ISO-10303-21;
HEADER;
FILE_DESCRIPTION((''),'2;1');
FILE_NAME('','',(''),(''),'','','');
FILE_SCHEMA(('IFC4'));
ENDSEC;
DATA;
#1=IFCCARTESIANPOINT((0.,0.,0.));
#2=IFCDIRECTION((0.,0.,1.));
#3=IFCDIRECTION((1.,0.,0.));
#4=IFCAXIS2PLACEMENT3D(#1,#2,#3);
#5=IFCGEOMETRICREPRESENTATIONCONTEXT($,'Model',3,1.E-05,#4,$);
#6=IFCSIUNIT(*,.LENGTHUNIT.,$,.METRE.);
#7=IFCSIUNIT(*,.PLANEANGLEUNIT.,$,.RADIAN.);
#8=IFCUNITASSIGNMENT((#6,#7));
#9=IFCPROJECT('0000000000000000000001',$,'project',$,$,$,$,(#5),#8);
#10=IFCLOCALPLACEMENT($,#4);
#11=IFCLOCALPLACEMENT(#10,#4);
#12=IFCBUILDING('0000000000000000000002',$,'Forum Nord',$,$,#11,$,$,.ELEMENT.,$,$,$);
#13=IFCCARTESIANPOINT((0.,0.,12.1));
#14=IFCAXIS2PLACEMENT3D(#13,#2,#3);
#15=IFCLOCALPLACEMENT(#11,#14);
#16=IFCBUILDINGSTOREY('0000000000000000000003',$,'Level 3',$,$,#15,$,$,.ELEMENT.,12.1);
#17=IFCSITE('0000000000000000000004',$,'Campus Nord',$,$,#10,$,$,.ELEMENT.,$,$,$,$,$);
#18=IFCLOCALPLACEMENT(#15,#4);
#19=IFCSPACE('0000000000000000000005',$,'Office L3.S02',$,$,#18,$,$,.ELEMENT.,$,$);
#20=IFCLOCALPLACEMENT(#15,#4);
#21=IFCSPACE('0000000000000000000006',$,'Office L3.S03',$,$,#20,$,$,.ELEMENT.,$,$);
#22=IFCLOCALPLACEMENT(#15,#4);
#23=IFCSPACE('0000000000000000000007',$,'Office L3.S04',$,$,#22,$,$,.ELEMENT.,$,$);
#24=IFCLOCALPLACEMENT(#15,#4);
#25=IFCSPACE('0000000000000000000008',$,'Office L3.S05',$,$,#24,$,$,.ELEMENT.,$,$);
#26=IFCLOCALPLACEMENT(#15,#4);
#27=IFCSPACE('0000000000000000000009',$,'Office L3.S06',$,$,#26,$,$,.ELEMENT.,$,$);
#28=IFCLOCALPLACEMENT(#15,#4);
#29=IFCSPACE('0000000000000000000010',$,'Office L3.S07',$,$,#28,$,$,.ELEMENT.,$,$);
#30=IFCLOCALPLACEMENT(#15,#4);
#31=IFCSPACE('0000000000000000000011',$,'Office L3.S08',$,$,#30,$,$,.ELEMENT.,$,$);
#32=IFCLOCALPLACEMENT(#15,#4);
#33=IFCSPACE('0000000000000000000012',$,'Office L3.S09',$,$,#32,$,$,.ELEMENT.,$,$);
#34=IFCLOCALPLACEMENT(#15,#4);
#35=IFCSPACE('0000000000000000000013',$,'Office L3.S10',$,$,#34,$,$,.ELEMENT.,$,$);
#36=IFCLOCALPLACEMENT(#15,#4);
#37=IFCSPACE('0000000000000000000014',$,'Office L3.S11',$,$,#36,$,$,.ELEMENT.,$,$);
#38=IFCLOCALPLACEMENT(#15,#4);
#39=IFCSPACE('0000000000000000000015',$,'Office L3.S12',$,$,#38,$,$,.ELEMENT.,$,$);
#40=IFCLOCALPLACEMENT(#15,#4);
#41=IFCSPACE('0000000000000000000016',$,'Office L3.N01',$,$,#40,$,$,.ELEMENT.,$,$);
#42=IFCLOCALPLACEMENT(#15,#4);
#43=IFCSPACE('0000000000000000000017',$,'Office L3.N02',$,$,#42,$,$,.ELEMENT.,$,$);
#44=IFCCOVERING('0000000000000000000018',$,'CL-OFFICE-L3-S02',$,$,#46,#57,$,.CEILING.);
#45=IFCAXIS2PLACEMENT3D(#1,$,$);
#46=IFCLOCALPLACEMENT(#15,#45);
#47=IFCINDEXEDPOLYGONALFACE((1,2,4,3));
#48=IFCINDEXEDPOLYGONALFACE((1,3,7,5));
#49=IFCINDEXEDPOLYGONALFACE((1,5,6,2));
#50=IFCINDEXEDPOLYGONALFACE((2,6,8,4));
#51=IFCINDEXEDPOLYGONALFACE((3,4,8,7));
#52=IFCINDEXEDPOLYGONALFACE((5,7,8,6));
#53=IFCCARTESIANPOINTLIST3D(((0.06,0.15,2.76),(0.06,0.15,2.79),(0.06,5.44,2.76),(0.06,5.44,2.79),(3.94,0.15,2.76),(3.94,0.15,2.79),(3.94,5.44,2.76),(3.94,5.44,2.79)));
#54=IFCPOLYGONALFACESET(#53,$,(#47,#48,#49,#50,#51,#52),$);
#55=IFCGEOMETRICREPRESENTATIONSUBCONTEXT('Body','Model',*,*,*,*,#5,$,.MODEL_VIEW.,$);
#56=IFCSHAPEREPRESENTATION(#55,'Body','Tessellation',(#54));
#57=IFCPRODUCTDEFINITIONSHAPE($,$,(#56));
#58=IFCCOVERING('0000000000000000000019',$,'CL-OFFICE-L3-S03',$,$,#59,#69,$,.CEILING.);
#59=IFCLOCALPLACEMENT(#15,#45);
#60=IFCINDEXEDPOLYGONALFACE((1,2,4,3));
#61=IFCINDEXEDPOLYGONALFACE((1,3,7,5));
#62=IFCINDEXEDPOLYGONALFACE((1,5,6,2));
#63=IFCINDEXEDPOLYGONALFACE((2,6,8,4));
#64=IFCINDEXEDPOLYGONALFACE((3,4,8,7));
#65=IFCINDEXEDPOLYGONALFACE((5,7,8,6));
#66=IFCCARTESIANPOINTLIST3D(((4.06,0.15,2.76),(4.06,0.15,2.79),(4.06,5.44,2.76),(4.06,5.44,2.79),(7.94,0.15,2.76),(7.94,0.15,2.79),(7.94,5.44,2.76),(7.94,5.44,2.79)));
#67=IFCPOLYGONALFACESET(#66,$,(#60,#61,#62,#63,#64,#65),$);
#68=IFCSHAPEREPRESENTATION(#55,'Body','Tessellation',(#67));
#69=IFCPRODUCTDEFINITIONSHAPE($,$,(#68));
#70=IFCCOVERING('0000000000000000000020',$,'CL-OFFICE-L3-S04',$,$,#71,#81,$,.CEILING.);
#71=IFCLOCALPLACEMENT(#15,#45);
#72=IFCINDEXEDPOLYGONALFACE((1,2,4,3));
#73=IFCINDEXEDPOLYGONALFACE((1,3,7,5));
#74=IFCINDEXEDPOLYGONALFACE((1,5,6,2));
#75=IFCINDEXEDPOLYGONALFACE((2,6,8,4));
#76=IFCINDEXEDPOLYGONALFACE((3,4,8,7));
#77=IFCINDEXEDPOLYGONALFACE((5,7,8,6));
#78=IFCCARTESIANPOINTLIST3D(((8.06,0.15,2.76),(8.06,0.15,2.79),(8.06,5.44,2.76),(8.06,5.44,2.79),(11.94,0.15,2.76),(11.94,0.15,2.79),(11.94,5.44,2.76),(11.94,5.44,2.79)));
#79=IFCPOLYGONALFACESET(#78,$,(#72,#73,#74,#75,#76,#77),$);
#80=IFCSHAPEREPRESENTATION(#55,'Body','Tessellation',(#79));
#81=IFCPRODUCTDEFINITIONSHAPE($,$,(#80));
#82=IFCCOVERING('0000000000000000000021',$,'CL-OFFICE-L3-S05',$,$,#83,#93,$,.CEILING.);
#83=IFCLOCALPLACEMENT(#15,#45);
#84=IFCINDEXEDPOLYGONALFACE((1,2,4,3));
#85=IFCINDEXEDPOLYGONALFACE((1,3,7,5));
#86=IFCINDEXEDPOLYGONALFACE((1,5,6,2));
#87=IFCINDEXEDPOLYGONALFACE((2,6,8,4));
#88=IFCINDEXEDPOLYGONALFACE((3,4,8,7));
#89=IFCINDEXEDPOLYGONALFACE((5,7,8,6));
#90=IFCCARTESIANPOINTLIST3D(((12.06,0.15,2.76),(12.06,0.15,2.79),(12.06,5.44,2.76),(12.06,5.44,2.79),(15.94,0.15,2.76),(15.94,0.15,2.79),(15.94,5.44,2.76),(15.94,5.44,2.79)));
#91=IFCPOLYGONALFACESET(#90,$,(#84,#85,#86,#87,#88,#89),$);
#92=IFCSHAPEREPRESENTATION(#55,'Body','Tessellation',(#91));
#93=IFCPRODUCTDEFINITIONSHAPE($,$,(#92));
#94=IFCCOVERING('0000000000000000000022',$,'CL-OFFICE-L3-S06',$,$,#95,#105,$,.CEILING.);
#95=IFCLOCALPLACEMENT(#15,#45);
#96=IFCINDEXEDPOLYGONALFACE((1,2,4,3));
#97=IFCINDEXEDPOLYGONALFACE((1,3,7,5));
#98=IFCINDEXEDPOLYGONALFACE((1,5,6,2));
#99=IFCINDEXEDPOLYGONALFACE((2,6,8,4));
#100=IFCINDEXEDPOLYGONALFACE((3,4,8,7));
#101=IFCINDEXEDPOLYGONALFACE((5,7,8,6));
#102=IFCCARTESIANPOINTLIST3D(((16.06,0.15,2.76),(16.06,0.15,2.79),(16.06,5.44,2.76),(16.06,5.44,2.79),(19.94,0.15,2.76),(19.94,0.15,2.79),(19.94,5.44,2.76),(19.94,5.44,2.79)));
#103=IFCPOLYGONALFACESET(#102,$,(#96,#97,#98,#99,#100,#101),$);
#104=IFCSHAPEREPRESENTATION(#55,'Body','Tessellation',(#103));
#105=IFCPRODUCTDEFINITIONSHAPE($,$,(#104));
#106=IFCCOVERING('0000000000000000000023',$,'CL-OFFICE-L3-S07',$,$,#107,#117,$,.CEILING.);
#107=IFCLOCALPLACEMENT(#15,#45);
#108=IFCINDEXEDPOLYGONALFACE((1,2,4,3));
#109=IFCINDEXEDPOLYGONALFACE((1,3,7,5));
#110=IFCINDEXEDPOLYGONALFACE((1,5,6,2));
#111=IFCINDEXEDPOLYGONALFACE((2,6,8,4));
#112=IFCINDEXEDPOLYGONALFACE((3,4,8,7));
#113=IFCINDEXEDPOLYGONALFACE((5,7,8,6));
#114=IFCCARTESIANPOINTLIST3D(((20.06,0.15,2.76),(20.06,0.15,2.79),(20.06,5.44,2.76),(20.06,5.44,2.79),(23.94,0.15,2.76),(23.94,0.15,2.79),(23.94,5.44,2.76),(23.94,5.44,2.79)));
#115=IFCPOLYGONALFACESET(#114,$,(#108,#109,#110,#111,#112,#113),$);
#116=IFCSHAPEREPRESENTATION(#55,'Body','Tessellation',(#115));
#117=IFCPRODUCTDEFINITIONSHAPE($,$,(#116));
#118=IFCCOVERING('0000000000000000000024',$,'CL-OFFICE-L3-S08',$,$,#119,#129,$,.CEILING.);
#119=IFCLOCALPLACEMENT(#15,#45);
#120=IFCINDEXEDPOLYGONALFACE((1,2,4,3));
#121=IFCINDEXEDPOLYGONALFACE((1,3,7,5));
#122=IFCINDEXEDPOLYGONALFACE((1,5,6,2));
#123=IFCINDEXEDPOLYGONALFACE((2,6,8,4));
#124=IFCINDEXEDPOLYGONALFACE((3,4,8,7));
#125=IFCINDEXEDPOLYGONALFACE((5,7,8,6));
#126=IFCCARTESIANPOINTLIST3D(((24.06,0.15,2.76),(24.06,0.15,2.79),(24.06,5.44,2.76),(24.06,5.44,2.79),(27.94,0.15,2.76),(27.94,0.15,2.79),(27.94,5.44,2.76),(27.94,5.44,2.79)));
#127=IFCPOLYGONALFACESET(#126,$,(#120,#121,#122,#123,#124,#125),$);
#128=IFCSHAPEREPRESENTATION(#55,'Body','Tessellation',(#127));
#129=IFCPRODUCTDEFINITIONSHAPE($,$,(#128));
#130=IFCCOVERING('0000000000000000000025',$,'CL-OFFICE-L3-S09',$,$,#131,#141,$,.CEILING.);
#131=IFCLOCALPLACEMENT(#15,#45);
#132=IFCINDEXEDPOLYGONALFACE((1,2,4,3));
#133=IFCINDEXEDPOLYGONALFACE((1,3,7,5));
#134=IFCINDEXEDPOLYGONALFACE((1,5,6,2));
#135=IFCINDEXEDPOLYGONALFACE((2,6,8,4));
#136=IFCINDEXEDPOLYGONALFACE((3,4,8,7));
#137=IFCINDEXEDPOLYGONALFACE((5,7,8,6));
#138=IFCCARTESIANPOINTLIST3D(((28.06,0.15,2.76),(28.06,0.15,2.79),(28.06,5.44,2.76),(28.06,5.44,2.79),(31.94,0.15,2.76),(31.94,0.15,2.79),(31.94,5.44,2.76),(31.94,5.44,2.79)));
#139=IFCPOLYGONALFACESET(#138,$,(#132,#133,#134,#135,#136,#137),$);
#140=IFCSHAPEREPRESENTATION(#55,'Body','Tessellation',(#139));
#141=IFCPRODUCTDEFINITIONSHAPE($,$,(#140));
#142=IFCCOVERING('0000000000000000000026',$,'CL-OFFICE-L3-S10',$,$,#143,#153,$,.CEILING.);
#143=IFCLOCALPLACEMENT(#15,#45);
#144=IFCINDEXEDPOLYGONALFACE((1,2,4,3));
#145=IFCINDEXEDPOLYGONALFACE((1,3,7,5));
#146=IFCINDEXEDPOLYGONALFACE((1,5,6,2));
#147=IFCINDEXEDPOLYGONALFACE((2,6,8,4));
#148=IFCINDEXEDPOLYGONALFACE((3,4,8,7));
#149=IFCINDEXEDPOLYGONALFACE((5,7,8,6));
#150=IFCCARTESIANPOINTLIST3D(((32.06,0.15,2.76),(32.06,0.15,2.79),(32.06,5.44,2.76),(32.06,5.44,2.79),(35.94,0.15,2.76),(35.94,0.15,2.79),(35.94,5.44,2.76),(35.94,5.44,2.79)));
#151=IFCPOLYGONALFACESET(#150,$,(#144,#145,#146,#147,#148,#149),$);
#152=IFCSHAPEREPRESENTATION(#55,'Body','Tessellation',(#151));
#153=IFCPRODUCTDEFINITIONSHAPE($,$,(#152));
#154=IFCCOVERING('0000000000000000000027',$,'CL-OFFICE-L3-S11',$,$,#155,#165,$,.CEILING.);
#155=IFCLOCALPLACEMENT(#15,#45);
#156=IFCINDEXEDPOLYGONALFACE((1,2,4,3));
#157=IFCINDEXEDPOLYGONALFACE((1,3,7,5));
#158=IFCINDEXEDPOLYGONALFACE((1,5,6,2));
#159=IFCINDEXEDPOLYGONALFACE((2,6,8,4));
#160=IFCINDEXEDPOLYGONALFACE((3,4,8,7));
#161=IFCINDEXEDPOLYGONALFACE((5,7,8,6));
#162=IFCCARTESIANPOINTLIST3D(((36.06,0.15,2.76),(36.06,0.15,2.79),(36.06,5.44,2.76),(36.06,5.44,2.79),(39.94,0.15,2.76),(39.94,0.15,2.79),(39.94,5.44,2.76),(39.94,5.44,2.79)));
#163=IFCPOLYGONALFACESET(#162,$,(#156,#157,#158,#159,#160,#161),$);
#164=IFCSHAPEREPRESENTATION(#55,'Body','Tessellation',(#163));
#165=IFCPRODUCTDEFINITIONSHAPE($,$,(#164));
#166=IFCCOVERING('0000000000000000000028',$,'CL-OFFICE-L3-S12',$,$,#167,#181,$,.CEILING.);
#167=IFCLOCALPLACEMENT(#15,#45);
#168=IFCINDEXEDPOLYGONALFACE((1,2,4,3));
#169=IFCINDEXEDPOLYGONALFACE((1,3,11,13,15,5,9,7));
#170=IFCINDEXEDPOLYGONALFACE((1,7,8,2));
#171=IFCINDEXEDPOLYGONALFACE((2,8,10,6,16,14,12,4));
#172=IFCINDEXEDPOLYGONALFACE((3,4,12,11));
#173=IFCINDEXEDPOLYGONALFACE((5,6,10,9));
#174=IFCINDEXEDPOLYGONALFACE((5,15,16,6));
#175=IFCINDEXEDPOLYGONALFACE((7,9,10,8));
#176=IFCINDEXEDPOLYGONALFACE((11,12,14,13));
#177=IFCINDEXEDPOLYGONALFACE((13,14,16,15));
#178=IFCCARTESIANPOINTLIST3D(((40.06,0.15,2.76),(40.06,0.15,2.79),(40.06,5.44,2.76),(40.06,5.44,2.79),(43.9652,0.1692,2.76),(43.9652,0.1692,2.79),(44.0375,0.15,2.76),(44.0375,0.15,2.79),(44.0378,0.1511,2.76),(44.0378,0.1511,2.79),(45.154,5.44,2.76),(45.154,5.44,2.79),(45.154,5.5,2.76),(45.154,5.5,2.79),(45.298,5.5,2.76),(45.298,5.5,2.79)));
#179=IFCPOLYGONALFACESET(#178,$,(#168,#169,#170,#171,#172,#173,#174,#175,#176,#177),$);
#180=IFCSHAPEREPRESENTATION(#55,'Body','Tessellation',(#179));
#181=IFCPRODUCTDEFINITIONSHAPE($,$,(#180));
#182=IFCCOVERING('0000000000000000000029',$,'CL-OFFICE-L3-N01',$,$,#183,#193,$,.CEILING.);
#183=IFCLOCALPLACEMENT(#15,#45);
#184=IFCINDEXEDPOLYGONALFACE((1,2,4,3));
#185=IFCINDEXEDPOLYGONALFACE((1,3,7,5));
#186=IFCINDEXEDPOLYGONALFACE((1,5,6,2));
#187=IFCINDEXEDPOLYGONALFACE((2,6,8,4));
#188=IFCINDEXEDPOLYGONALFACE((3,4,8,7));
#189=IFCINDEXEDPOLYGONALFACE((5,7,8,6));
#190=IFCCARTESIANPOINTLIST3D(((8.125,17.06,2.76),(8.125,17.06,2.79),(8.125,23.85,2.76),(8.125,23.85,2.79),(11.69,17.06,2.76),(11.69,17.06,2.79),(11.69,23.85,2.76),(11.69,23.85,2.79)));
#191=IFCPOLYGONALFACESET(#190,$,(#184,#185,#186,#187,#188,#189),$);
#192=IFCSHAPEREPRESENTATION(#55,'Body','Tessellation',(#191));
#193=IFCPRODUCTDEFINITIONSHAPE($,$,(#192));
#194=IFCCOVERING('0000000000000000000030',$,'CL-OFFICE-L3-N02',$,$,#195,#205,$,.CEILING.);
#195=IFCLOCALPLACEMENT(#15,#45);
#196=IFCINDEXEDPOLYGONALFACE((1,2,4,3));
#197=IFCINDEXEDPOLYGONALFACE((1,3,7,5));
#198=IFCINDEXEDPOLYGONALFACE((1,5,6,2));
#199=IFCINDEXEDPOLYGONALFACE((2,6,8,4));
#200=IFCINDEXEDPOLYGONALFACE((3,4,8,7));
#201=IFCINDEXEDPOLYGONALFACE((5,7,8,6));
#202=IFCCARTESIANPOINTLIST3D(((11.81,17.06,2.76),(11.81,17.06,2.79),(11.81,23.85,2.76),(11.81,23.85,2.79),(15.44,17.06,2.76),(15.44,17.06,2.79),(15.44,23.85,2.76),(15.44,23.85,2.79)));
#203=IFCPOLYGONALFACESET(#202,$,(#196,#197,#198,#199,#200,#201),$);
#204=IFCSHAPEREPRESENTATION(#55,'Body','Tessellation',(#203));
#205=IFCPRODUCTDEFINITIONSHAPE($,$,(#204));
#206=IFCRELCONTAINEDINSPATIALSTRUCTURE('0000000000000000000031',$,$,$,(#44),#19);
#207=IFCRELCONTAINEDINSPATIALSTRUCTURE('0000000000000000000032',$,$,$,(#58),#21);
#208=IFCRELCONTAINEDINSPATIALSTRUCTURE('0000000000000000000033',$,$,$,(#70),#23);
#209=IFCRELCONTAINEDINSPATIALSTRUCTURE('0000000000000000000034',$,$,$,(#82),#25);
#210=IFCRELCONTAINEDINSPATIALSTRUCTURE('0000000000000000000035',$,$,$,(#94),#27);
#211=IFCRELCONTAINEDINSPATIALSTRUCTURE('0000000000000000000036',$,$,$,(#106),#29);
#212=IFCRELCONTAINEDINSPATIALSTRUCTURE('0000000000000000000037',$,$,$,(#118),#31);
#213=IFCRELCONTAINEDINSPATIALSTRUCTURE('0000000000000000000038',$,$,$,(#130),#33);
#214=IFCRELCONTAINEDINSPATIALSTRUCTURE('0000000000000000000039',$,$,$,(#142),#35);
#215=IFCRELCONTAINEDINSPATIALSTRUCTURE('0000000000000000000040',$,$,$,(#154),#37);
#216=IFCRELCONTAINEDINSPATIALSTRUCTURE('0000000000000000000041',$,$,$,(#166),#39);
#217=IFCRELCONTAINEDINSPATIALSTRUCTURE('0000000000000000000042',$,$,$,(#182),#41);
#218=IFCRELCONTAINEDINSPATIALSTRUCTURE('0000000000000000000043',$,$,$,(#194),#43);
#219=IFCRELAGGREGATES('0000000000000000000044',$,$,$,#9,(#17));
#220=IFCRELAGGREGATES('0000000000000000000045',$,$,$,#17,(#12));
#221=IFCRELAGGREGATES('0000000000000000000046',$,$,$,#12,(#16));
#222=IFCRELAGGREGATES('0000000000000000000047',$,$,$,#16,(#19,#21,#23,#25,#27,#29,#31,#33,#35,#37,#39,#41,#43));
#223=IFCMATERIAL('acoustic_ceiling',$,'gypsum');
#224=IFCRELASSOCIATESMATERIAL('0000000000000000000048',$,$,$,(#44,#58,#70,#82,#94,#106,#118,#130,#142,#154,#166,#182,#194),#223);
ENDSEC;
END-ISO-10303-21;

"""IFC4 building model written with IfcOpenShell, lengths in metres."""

from ifc_helpers import new_model, si_unit, frame, origin_with_axes, place, context, subcontext, project, spatial, polyline, outline, extrude, material, element, save


model = new_model("IFC4")

# Units and contexts
model_context = context("Model", 3, precision=1e-05, world=origin_with_axes())
body_context = subcontext(model_context, "Body", "Model", "MODEL_VIEW")
ifc_project = project(units=[si_unit("LENGTHUNIT", "METRE"), si_unit("PLANEANGLEUNIT", "RADIAN")], contexts=[model_context])

# Site, building, storey, space
site_placement = place(None, origin_with_axes())
site = spatial("IfcSite", under=ifc_project, at=site_placement, Name="Campus Nord", CompositionType="ELEMENT")
building_placement = place(site_placement, origin_with_axes())
building = spatial("IfcBuilding", under=site, at=building_placement, Name="Forum Nord", CompositionType="ELEMENT")
storey_placement = place(building_placement, frame((0.0, 0.0, 12.1), z_axis=(0.0, 0.0, 1.0), x_axis=(1.0, 0.0, 0.0)))
storey = spatial("IfcBuildingStorey", under=building, at=storey_placement, Name="Level 3", CompositionType="ELEMENT", Elevation=12.1)
space_1_placement = place(storey_placement, origin_with_axes())
space_1 = spatial("IfcSpace", under=storey, at=space_1_placement, Name="Office L3.S02", CompositionType="ELEMENT")

# Covering
ifc_material = material(Name="acoustic_ceiling", Category="gypsum")
covering_1_placement = place(storey_placement, frame((0.0, 0.0, 2.76), z_axis=(0.0, 0.0, 1.0), x_axis=(1.0, 0.0, 0.0)))
element("IfcCovering", 1, at=covering_1_placement, inside=space_1, material=ifc_material, Name="CL-OFFICE-L3-S02", PredefinedType="CEILING", context=body_context, shape_type="SweptSolid", body=[
    extrude(outline(polyline([(0.06, 5.44), (0.06, 0.15), (3.94, 0.15), (3.94, 5.44), (0.06, 5.44)])), origin_with_axes(), (0.0, 0.0, 1.0), 0.03),
])

# Shared definitions
space_2_placement = place(storey_placement, origin_with_axes())
space_2 = spatial("IfcSpace", under=storey, at=space_2_placement, Name="Office L3.S03", CompositionType="ELEMENT")

# Covering
covering_2_placement = place(storey_placement, frame((0.0, 0.0, 2.76), z_axis=(0.0, 0.0, 1.0), x_axis=(1.0, 0.0, 0.0)))
element("IfcCovering", 2, at=covering_2_placement, inside=space_2, material=ifc_material, Name="CL-OFFICE-L3-S03", PredefinedType="CEILING", context=body_context, shape_type="SweptSolid", body=[
    extrude(outline(polyline([(4.06, 5.44), (4.06, 0.15), (7.94, 0.15), (7.94, 5.44), (4.06, 5.44)])), origin_with_axes(), (0.0, 0.0, 1.0), 0.03),
])

# Shared definitions
space_3_placement = place(storey_placement, origin_with_axes())
space_3 = spatial("IfcSpace", under=storey, at=space_3_placement, Name="Office L3.S04", CompositionType="ELEMENT")

# Covering
covering_3_placement = place(storey_placement, frame((0.0, 0.0, 2.76), z_axis=(0.0, 0.0, 1.0), x_axis=(1.0, 0.0, 0.0)))
element("IfcCovering", 3, at=covering_3_placement, inside=space_3, material=ifc_material, Name="CL-OFFICE-L3-S04", PredefinedType="CEILING", context=body_context, shape_type="SweptSolid", body=[
    extrude(outline(polyline([(8.06, 5.44), (8.06, 0.15), (11.94, 0.15), (11.94, 5.44), (8.06, 5.44)])), origin_with_axes(), (0.0, 0.0, 1.0), 0.03),
])

# Shared definitions
space_4_placement = place(storey_placement, origin_with_axes())
space_4 = spatial("IfcSpace", under=storey, at=space_4_placement, Name="Office L3.S05", CompositionType="ELEMENT")

# Covering
covering_4_placement = place(storey_placement, frame((0.0, 0.0, 2.76), z_axis=(0.0, 0.0, 1.0), x_axis=(1.0, 0.0, 0.0)))
element("IfcCovering", 4, at=covering_4_placement, inside=space_4, material=ifc_material, Name="CL-OFFICE-L3-S05", PredefinedType="CEILING", context=body_context, shape_type="SweptSolid", body=[
    extrude(outline(polyline([(12.06, 5.44), (12.06, 0.15), (15.94, 0.15), (15.94, 5.44), (12.06, 5.44)])), origin_with_axes(), (0.0, 0.0, 1.0), 0.03),
])

# Shared definitions
space_5_placement = place(storey_placement, origin_with_axes())
space_5 = spatial("IfcSpace", under=storey, at=space_5_placement, Name="Office L3.S06", CompositionType="ELEMENT")

# Covering
covering_5_placement = place(storey_placement, frame((0.0, 0.0, 2.76), z_axis=(0.0, 0.0, 1.0), x_axis=(1.0, 0.0, 0.0)))
element("IfcCovering", 5, at=covering_5_placement, inside=space_5, material=ifc_material, Name="CL-OFFICE-L3-S06", PredefinedType="CEILING", context=body_context, shape_type="SweptSolid", body=[
    extrude(outline(polyline([(16.06, 5.44), (16.06, 0.15), (19.94, 0.15), (19.94, 5.44), (16.06, 5.44)])), origin_with_axes(), (0.0, 0.0, 1.0), 0.03),
])

# Shared definitions
space_6_placement = place(storey_placement, origin_with_axes())
space_6 = spatial("IfcSpace", under=storey, at=space_6_placement, Name="Office L3.S07", CompositionType="ELEMENT")

# Covering
covering_6_placement = place(storey_placement, frame((0.0, 0.0, 2.76), z_axis=(0.0, 0.0, 1.0), x_axis=(1.0, 0.0, 0.0)))
element("IfcCovering", 6, at=covering_6_placement, inside=space_6, material=ifc_material, Name="CL-OFFICE-L3-S07", PredefinedType="CEILING", context=body_context, shape_type="SweptSolid", body=[
    extrude(outline(polyline([(20.06, 5.44), (20.06, 0.15), (23.94, 0.15), (23.94, 5.44), (20.06, 5.44)])), origin_with_axes(), (0.0, 0.0, 1.0), 0.03),
])

# Shared definitions
space_7_placement = place(storey_placement, origin_with_axes())
space_7 = spatial("IfcSpace", under=storey, at=space_7_placement, Name="Office L3.S08", CompositionType="ELEMENT")

# Covering
covering_7_placement = place(storey_placement, frame((0.0, 0.0, 2.76), z_axis=(0.0, 0.0, 1.0), x_axis=(1.0, 0.0, 0.0)))
element("IfcCovering", 7, at=covering_7_placement, inside=space_7, material=ifc_material, Name="CL-OFFICE-L3-S08", PredefinedType="CEILING", context=body_context, shape_type="SweptSolid", body=[
    extrude(outline(polyline([(24.06, 5.44), (24.06, 0.15), (27.94, 0.15), (27.94, 5.44), (24.06, 5.44)])), origin_with_axes(), (0.0, 0.0, 1.0), 0.03),
])

# Shared definitions
space_8_placement = place(storey_placement, origin_with_axes())
space_8 = spatial("IfcSpace", under=storey, at=space_8_placement, Name="Office L3.S09", CompositionType="ELEMENT")

# Covering
covering_8_placement = place(storey_placement, frame((0.0, 0.0, 2.76), z_axis=(0.0, 0.0, 1.0), x_axis=(1.0, 0.0, 0.0)))
element("IfcCovering", 8, at=covering_8_placement, inside=space_8, material=ifc_material, Name="CL-OFFICE-L3-S09", PredefinedType="CEILING", context=body_context, shape_type="SweptSolid", body=[
    extrude(outline(polyline([(28.06, 5.44), (28.06, 0.15), (31.94, 0.15), (31.94, 5.44), (28.06, 5.44)])), origin_with_axes(), (0.0, 0.0, 1.0), 0.03),
])

# Shared definitions
space_9_placement = place(storey_placement, origin_with_axes())
space_9 = spatial("IfcSpace", under=storey, at=space_9_placement, Name="Office L3.S10", CompositionType="ELEMENT")

# Covering
covering_9_placement = place(storey_placement, frame((0.0, 0.0, 2.76), z_axis=(0.0, 0.0, 1.0), x_axis=(1.0, 0.0, 0.0)))
element("IfcCovering", 9, at=covering_9_placement, inside=space_9, material=ifc_material, Name="CL-OFFICE-L3-S10", PredefinedType="CEILING", context=body_context, shape_type="SweptSolid", body=[
    extrude(outline(polyline([(32.06, 5.44), (32.06, 0.15), (35.94, 0.15), (35.94, 5.44), (32.06, 5.44)])), origin_with_axes(), (0.0, 0.0, 1.0), 0.03),
])

# Shared definitions
space_10_placement = place(storey_placement, origin_with_axes())
space_10 = spatial("IfcSpace", under=storey, at=space_10_placement, Name="Office L3.S11", CompositionType="ELEMENT")

# Covering
covering_10_placement = place(storey_placement, frame((0.0, 0.0, 2.76), z_axis=(0.0, 0.0, 1.0), x_axis=(1.0, 0.0, 0.0)))
element("IfcCovering", 10, at=covering_10_placement, inside=space_10, material=ifc_material, Name="CL-OFFICE-L3-S11", PredefinedType="CEILING", context=body_context, shape_type="SweptSolid", body=[
    extrude(outline(polyline([(36.06, 5.44), (36.06, 0.15), (39.94, 0.15), (39.94, 5.44), (36.06, 5.44)])), origin_with_axes(), (0.0, 0.0, 1.0), 0.03),
])

# Shared definitions
space_11_placement = place(storey_placement, origin_with_axes())
space_11 = spatial("IfcSpace", under=storey, at=space_11_placement, Name="Office L3.S12", CompositionType="ELEMENT")

# Covering
covering_11_placement = place(storey_placement, frame((0.0, 0.0, 2.76), z_axis=(0.0, 0.0, 1.0), x_axis=(1.0, 0.0, 0.0)))
element("IfcCovering", 11, at=covering_11_placement, inside=space_11, material=ifc_material, Name="CL-OFFICE-L3-S12", PredefinedType="CEILING", context=body_context, shape_type="SweptSolid", body=[
    extrude(outline(polyline([(40.06, 5.44), (40.06, 0.15), (44.0375, 0.15), (44.0378, 0.1511), (43.9652, 0.1692), (45.298, 5.5), (45.154, 5.5), (45.154, 5.44), (40.06, 5.44)])), origin_with_axes(), (0.0, 0.0, 1.0), 0.03),
])

# Shared definitions
space_12_placement = place(storey_placement, origin_with_axes())
space_12 = spatial("IfcSpace", under=storey, at=space_12_placement, Name="Office L3.N01", CompositionType="ELEMENT")

# Covering
covering_12_placement = place(storey_placement, frame((0.0, 0.0, 2.76), z_axis=(0.0, 0.0, 1.0), x_axis=(1.0, 0.0, 0.0)))
element("IfcCovering", 12, at=covering_12_placement, inside=space_12, material=ifc_material, Name="CL-OFFICE-L3-N01", PredefinedType="CEILING", context=body_context, shape_type="SweptSolid", body=[
    extrude(outline(polyline([(8.125, 23.85), (8.125, 17.06), (11.69, 17.06), (11.69, 23.85), (8.125, 23.85)])), origin_with_axes(), (0.0, 0.0, 1.0), 0.03),
])

# Shared definitions
space_13_placement = place(storey_placement, origin_with_axes())
space_13 = spatial("IfcSpace", under=storey, at=space_13_placement, Name="Office L3.N02", CompositionType="ELEMENT")

# Covering
covering_13_placement = place(storey_placement, frame((0.0, 0.0, 2.76), z_axis=(0.0, 0.0, 1.0), x_axis=(1.0, 0.0, 0.0)))
element("IfcCovering", 13, at=covering_13_placement, inside=space_13, material=ifc_material, Name="CL-OFFICE-L3-N02", PredefinedType="CEILING", context=body_context, shape_type="SweptSolid", body=[
    extrude(outline(polyline([(11.81, 23.85), (11.81, 17.06), (15.44, 17.06), (15.44, 23.85), (11.81, 23.85)])), origin_with_axes(), (0.0, 0.0, 1.0), 0.03),
])

save(model, "model.ifc")
